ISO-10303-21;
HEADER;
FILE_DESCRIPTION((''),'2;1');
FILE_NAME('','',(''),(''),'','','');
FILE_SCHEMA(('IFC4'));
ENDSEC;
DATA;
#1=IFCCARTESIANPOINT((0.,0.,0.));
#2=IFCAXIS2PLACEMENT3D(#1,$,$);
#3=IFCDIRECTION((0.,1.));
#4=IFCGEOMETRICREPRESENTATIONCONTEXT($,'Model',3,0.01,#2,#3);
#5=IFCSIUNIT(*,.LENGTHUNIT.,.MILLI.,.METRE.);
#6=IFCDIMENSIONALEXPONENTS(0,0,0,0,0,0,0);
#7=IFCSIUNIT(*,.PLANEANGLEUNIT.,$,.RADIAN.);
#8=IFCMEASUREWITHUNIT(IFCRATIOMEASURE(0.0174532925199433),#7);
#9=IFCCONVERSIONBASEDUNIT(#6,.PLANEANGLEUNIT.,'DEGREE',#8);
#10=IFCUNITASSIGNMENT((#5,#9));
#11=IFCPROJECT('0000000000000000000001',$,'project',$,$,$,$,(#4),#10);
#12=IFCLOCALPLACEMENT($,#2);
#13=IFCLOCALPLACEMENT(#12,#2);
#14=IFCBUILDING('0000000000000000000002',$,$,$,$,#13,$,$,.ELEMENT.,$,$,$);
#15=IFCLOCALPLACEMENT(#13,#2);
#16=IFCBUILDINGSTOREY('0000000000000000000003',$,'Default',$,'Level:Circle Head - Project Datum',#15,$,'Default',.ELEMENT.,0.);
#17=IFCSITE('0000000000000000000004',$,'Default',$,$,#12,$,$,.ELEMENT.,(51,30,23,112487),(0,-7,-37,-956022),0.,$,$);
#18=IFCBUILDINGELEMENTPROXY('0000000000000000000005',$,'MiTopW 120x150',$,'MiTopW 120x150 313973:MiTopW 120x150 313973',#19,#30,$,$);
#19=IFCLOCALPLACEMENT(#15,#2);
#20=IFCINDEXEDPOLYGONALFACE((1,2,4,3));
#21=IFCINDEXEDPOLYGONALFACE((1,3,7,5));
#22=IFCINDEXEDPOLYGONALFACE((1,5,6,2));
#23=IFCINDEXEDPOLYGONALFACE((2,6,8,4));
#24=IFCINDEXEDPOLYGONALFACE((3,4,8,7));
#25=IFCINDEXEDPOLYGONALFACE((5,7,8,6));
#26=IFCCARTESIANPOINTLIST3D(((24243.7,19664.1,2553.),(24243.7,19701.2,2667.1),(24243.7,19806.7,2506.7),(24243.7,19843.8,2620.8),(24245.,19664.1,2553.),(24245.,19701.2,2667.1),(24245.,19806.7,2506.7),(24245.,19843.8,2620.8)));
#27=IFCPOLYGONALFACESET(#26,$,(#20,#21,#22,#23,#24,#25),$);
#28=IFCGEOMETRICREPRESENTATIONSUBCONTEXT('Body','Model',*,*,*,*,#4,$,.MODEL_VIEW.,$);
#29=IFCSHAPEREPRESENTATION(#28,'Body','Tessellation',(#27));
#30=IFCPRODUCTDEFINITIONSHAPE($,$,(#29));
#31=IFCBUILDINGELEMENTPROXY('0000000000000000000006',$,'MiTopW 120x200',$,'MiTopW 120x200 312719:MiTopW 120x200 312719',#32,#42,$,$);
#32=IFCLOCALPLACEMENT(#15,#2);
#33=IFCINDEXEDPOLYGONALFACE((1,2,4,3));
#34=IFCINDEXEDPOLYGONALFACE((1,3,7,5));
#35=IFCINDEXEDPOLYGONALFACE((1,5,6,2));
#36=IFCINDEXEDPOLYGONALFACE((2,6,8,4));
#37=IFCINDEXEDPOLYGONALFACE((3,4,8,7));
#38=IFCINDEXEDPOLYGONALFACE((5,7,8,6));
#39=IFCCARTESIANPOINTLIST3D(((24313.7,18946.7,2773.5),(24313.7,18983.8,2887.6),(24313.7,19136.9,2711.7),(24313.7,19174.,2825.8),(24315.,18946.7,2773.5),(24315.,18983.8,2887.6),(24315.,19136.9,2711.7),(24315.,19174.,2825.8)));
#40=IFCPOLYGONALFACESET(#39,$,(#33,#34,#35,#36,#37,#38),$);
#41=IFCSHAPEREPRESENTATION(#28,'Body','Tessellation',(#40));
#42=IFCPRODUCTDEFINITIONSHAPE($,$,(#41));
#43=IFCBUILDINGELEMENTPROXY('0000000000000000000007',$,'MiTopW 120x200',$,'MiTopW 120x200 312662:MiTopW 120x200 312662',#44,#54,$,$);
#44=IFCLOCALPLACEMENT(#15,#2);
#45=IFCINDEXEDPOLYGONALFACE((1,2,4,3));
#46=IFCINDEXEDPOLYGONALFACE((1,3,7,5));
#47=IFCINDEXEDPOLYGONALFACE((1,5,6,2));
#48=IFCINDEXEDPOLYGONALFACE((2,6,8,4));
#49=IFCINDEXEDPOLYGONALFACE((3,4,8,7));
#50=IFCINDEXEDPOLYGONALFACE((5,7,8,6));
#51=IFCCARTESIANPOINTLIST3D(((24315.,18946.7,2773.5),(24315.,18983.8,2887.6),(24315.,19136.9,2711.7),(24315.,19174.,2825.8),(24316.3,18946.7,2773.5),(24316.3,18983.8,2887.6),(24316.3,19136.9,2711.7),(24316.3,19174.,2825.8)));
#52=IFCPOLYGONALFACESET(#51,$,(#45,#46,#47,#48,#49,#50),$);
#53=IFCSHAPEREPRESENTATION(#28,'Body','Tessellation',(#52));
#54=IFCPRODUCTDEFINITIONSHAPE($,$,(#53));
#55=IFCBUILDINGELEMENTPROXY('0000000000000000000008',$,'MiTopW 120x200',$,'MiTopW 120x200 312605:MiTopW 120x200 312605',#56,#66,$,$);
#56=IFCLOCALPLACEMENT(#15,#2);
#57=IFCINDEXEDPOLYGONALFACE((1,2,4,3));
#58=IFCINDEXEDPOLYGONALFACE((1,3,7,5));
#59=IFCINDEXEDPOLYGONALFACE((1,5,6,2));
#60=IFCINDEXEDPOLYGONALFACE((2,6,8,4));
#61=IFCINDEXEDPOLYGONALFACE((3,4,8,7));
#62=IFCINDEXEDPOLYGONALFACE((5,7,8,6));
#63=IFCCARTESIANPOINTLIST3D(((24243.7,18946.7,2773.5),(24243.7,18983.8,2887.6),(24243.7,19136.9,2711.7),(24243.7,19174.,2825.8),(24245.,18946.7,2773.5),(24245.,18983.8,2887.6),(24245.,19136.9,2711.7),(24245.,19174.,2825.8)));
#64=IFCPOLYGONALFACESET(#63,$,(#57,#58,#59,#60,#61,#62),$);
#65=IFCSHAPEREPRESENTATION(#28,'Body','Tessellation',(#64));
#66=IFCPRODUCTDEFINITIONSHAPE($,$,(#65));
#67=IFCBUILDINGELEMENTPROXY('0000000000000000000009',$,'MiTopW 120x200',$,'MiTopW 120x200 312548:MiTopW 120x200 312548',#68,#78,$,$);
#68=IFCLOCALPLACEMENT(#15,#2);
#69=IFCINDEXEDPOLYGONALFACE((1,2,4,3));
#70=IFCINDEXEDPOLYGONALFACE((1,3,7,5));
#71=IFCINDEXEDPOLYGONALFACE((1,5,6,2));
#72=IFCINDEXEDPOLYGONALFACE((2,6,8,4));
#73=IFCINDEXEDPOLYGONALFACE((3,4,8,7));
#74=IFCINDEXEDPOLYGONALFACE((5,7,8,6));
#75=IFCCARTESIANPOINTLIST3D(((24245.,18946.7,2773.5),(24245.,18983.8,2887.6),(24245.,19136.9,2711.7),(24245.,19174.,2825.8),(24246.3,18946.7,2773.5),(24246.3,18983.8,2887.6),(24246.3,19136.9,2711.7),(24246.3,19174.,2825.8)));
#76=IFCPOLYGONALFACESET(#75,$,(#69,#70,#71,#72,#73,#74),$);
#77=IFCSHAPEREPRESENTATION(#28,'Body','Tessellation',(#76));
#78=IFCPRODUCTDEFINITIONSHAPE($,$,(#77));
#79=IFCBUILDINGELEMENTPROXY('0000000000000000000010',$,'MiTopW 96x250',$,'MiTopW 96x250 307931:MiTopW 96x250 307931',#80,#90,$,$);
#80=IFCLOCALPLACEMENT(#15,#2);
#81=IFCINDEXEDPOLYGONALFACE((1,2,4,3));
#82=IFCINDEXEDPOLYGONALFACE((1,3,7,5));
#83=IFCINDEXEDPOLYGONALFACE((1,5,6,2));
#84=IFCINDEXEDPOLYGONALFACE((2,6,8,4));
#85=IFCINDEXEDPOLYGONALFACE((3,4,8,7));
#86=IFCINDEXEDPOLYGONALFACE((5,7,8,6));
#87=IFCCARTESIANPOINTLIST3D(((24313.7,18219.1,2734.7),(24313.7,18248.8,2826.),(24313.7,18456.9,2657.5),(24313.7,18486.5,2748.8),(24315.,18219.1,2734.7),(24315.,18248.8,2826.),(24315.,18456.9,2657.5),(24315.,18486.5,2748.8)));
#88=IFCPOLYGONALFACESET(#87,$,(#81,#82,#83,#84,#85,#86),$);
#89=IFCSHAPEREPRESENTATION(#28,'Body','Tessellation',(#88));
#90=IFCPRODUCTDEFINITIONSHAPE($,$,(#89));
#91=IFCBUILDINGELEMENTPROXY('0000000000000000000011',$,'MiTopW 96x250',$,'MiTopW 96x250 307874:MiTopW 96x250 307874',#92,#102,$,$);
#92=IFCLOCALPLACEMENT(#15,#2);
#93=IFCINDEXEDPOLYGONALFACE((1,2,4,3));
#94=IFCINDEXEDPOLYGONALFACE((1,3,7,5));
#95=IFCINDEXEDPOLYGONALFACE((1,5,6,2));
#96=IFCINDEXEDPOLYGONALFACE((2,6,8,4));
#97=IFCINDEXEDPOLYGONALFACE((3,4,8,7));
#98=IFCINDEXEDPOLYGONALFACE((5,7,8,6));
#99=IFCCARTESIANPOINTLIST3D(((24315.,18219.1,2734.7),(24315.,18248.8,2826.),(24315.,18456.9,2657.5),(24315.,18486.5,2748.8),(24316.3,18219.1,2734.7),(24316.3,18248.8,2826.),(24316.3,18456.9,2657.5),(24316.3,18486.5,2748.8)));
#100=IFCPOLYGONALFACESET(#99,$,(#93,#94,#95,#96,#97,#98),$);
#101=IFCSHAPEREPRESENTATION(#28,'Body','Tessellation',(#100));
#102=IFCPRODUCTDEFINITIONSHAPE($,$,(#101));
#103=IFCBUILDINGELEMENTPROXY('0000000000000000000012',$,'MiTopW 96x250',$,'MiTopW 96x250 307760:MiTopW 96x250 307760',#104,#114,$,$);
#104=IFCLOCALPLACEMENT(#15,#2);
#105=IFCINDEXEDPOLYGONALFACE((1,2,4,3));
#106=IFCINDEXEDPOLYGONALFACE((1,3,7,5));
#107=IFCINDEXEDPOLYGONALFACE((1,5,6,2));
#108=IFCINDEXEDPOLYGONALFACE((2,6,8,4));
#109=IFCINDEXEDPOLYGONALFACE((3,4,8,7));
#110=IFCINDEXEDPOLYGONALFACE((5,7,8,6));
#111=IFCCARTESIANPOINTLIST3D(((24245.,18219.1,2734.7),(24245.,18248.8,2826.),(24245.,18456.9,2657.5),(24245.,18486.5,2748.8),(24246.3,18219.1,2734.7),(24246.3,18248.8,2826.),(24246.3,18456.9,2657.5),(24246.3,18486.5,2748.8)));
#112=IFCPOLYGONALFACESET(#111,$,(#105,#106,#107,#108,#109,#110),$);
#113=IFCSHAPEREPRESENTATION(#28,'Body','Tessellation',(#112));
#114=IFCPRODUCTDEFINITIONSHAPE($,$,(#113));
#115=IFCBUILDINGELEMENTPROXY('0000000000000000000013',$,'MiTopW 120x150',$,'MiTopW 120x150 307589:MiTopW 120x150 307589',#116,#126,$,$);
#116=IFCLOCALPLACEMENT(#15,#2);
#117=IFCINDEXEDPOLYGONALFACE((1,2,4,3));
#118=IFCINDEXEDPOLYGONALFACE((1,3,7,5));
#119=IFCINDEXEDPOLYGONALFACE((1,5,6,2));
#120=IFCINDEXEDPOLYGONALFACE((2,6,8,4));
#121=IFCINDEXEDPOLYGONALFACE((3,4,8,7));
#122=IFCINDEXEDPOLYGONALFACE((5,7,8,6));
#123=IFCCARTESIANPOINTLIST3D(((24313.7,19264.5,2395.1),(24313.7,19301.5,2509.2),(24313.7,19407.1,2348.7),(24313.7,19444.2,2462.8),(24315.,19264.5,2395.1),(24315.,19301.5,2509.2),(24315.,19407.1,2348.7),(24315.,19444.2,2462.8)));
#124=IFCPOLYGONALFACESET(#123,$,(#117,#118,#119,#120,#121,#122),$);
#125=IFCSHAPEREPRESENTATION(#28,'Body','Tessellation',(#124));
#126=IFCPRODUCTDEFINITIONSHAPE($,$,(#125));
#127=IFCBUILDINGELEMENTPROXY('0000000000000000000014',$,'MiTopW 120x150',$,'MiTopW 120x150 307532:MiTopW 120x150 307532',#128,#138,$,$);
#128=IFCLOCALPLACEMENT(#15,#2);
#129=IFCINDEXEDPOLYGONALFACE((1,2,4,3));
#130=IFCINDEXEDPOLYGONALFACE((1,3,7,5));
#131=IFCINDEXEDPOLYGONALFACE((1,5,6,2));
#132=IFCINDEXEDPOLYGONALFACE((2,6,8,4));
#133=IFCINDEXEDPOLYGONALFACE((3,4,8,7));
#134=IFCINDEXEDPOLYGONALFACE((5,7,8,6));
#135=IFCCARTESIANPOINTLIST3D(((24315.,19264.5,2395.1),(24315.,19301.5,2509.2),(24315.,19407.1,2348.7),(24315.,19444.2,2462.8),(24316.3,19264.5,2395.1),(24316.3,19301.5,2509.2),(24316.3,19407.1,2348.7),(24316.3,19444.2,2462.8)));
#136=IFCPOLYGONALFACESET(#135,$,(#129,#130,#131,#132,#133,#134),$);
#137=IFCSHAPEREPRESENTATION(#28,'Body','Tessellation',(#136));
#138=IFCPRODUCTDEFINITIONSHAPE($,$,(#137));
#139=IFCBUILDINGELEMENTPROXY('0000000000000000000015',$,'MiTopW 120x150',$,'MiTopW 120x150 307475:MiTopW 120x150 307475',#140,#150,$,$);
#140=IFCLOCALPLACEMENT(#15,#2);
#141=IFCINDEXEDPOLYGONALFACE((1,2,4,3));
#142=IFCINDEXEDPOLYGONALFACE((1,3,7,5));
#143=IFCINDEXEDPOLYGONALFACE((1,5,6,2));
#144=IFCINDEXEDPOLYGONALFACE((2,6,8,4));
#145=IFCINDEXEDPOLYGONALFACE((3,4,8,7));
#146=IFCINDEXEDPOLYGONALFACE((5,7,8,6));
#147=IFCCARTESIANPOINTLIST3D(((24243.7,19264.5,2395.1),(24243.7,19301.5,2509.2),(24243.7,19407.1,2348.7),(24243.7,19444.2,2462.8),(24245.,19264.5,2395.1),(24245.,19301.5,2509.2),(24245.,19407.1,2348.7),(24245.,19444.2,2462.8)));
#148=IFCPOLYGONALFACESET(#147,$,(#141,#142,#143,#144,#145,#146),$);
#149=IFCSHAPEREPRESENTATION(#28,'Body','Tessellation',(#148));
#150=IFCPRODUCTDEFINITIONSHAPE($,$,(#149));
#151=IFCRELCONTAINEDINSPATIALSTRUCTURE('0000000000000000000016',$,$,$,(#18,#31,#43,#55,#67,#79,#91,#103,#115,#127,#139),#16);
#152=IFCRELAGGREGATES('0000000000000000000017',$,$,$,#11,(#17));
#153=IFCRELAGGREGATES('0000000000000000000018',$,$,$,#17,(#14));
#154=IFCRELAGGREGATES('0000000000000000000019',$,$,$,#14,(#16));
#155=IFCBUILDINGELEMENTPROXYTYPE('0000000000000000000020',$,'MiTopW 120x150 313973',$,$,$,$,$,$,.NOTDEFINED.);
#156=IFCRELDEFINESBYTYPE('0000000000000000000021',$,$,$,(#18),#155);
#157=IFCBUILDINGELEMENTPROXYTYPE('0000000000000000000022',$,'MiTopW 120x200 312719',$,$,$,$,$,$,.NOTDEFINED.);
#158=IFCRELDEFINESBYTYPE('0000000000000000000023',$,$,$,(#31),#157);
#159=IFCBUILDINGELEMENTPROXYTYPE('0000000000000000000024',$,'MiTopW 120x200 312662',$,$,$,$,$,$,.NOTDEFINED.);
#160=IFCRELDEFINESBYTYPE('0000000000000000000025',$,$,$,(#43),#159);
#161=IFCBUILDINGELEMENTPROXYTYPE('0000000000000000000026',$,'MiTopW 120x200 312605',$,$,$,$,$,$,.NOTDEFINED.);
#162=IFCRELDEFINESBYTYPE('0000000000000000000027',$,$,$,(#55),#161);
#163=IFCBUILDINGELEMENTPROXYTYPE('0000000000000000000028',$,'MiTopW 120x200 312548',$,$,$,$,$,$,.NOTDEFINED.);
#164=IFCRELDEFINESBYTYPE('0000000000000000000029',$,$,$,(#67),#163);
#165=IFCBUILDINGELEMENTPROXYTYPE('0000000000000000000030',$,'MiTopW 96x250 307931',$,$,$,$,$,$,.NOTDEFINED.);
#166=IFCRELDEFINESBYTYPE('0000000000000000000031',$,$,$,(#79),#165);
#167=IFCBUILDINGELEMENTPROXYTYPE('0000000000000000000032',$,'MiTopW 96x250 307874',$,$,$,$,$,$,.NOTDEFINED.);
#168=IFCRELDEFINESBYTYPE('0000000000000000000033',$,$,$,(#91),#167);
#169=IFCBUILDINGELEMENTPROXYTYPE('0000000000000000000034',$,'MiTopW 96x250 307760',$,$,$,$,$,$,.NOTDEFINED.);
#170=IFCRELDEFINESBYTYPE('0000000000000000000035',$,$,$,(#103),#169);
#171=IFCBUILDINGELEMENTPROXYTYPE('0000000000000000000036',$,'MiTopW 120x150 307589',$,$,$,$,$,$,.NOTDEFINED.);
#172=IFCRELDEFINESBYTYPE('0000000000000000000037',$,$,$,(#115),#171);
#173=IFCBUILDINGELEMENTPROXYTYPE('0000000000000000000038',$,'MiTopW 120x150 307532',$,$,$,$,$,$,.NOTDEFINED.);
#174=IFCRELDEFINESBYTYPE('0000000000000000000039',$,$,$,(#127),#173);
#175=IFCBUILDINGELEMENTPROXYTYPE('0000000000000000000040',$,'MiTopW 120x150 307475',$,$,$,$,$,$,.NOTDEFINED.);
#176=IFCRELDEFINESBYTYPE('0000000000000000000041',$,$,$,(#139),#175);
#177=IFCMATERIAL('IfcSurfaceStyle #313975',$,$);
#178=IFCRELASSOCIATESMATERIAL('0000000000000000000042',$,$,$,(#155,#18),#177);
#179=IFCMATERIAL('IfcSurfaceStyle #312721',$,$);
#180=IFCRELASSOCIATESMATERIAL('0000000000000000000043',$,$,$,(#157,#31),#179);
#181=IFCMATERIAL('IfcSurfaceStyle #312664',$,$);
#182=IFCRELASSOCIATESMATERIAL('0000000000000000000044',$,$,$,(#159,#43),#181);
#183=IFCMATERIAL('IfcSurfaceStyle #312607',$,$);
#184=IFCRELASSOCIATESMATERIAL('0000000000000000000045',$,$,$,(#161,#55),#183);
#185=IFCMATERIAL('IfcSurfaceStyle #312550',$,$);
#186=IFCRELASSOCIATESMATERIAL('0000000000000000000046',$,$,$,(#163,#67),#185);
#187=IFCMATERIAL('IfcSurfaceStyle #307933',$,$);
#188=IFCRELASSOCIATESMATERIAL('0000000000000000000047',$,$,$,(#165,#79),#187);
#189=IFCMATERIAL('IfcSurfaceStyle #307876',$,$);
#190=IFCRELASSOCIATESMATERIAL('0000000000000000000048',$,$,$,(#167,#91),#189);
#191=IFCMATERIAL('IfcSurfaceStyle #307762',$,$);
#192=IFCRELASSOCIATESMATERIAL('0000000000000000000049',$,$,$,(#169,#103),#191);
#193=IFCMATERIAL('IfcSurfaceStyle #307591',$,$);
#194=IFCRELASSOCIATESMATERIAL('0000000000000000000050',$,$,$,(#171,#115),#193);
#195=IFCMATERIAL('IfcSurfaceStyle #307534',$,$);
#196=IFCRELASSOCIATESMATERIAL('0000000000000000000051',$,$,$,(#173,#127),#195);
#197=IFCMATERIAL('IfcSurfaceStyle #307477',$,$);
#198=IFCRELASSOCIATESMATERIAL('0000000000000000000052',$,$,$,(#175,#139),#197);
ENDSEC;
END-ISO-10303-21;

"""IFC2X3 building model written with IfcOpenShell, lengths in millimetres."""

from ifc_helpers import new_model, entity, si_unit, converted_unit, direction, frame, origin, place, context, subcontext, project, spatial, polyline, outline, extrude, source, transform, mapped, material, type_object, type_shapes, element, save


model = new_model("IFC2X3")

# Units and contexts
model_context = context("Model", 3, precision=0.01, world=origin(), true_north=direction((0.0, 1.0)))
body_context = subcontext(model_context, "Body", "Model", "MODEL_VIEW")
ifc_project = project(units=[si_unit("LENGTHUNIT", "METRE", prefix="MILLI"), converted_unit("PLANEANGLEUNIT", "DEGREE", entity("IfcRatioMeasure", 0.0174532925199433), si_unit("PLANEANGLEUNIT", "RADIAN"), dimensions=[0, 0, 0, 0, 0, 0, 0])], contexts=[model_context])

# Site, building, storey
site_placement = place(None, origin())
site = spatial("IfcSite", under=ifc_project, at=site_placement, Name="Default", CompositionType="ELEMENT", RefLatitude=(51, 30, 23, 112487), RefLongitude=(0, -7, -37, -956022), RefElevation=0.0)
building_placement = place(site_placement, origin())
building = spatial("IfcBuilding", under=site, at=building_placement, CompositionType="ELEMENT")
storey_placement = place(building_placement, origin())
storey = spatial("IfcBuildingStorey", under=building, at=storey_placement, Name="Default", ObjectType="Level:Circle Head - Project Datum", LongName="Default", CompositionType="ELEMENT", Elevation=0.0)

# Building element proxies
ifc_material_1 = material(Name="IfcSurfaceStyle #313975")
building_element_proxy_type_1 = type_object("IfcBuildingElementProxyType", Name="MiTopW 120x150 313973", PredefinedType="NOTDEFINED", material=ifc_material_1)
shared_shape_1 = source(origin(), body_context, "Body", "SweptSolid", [
    extrude(outline(polyline([(-75.0, -60.0), (75.0, -60.0), (75.0, 60.0), (-75.0, 60.0), (-75.0, -60.0)])), frame((75.0, 60.0, 0.0), z_axis=(0.0, 0.0, 1.0), x_axis=(-1.0, 0.0, 0.0)), (0.0, 0.0, 1.0), 1.3),
])
type_shapes(building_element_proxy_type_1, [shared_shape_1])
proxy_1_placement = place(building_placement, frame((24245.0, 19806.7, 2506.7), z_axis=(-1.0, 0.0, 0.0), x_axis=(0.0, -0.951057, 0.309017)))
element("IfcBuildingElementProxy", 1, at=proxy_1_placement, inside=storey, type_object=building_element_proxy_type_1, material=ifc_material_1, Name="MiTopW 120x150", ObjectType="MiTopW 120x150 313973:MiTopW 120x150 313973", context=body_context, shape_type="MappedRepresentation", body=[
    mapped(shared_shape_1, transform((0.0, 0.0, 0.0), scale=1.0)),
])
ifc_material_2 = material(Name="IfcSurfaceStyle #312721")
building_element_proxy_type_2 = type_object("IfcBuildingElementProxyType", Name="MiTopW 120x200 312719", PredefinedType="NOTDEFINED", material=ifc_material_2)
shared_shape_2 = source(origin(), body_context, "Body", "SweptSolid", [
    extrude(outline(polyline([(-100.0, -60.0), (100.0, -60.0), (100.0, 60.0), (-100.0, 60.0), (-100.0, -60.0)])), frame((100.0, 60.0, 0.0), z_axis=(0.0, 0.0, 1.0), x_axis=(-1.0, 0.0, 0.0)), (0.0, 0.0, 1.0), 1.3),
])
type_shapes(building_element_proxy_type_2, [shared_shape_2])
proxy_2_placement = place(building_placement, frame((24315.0, 19136.9, 2711.7), z_axis=(-1.0, 0.0, 0.0), x_axis=(0.0, -0.951057, 0.309017)))
element("IfcBuildingElementProxy", 2, at=proxy_2_placement, inside=storey, type_object=building_element_proxy_type_2, material=ifc_material_2, Name="MiTopW 120x200", ObjectType="MiTopW 120x200 312719:MiTopW 120x200 312719", context=body_context, shape_type="MappedRepresentation", body=[
    mapped(shared_shape_2, transform((0.0, 0.0, 0.0), scale=1.0)),
])
ifc_material_3 = material(Name="IfcSurfaceStyle #312664")
building_element_proxy_type_3 = type_object("IfcBuildingElementProxyType", Name="MiTopW 120x200 312662", PredefinedType="NOTDEFINED", material=ifc_material_3)
shared_shape_3 = source(origin(), body_context, "Body", "SweptSolid", [
    extrude(outline(polyline([(-100.0, -60.0), (100.0, -60.0), (100.0, 60.0), (-100.0, 60.0), (-100.0, -60.0)])), frame((100.0, 60.0, 0.0), z_axis=(0.0, 0.0, 1.0), x_axis=(-1.0, 0.0, 0.0)), (0.0, 0.0, 1.0), 1.3),
])
type_shapes(building_element_proxy_type_3, [shared_shape_3])
proxy_3_placement = place(building_placement, frame((24316.3, 19136.9, 2711.7), z_axis=(-1.0, 0.0, 0.0), x_axis=(0.0, -0.951057, 0.309017)))
element("IfcBuildingElementProxy", 3, at=proxy_3_placement, inside=storey, type_object=building_element_proxy_type_3, material=ifc_material_3, Name="MiTopW 120x200", ObjectType="MiTopW 120x200 312662:MiTopW 120x200 312662", context=body_context, shape_type="MappedRepresentation", body=[
    mapped(shared_shape_3, transform((0.0, 0.0, 0.0), scale=1.0)),
])
ifc_material_4 = material(Name="IfcSurfaceStyle #312607")
building_element_proxy_type_4 = type_object("IfcBuildingElementProxyType", Name="MiTopW 120x200 312605", PredefinedType="NOTDEFINED", material=ifc_material_4)
shared_shape_4 = source(origin(), body_context, "Body", "SweptSolid", [
    extrude(outline(polyline([(-100.0, -60.0), (100.0, -60.0), (100.0, 60.0), (-100.0, 60.0), (-100.0, -60.0)])), frame((100.0, 60.0, 0.0), z_axis=(0.0, 0.0, 1.0), x_axis=(-1.0, 0.0, 0.0)), (0.0, 0.0, 1.0), 1.3),
])
type_shapes(building_element_proxy_type_4, [shared_shape_4])
proxy_4_placement = place(building_placement, frame((24245.0, 19136.9, 2711.7), z_axis=(-1.0, 0.0, 0.0), x_axis=(0.0, -0.951057, 0.309017)))
element("IfcBuildingElementProxy", 4, at=proxy_4_placement, inside=storey, type_object=building_element_proxy_type_4, material=ifc_material_4, Name="MiTopW 120x200", ObjectType="MiTopW 120x200 312605:MiTopW 120x200 312605", context=body_context, shape_type="MappedRepresentation", body=[
    mapped(shared_shape_4, transform((0.0, 0.0, 0.0), scale=1.0)),
])
ifc_material_5 = material(Name="IfcSurfaceStyle #312550")
building_element_proxy_type_5 = type_object("IfcBuildingElementProxyType", Name="MiTopW 120x200 312548", PredefinedType="NOTDEFINED", material=ifc_material_5)
shared_shape_5 = source(origin(), body_context, "Body", "SweptSolid", [
    extrude(outline(polyline([(-100.0, -60.0), (100.0, -60.0), (100.0, 60.0), (-100.0, 60.0), (-100.0, -60.0)])), frame((100.0, 60.0, 0.0), z_axis=(0.0, 0.0, 1.0), x_axis=(-1.0, 0.0, 0.0)), (0.0, 0.0, 1.0), 1.3),
])
type_shapes(building_element_proxy_type_5, [shared_shape_5])
proxy_5_placement = place(building_placement, frame((24246.3, 19136.9, 2711.7), z_axis=(-1.0, 0.0, 0.0), x_axis=(0.0, -0.951057, 0.309017)))
element("IfcBuildingElementProxy", 5, at=proxy_5_placement, inside=storey, type_object=building_element_proxy_type_5, material=ifc_material_5, Name="MiTopW 120x200", ObjectType="MiTopW 120x200 312548:MiTopW 120x200 312548", context=body_context, shape_type="MappedRepresentation", body=[
    mapped(shared_shape_5, transform((0.0, 0.0, 0.0), scale=1.0)),
])
ifc_material_6 = material(Name="IfcSurfaceStyle #307933")
building_element_proxy_type_6 = type_object("IfcBuildingElementProxyType", Name="MiTopW 96x250 307931", PredefinedType="NOTDEFINED", material=ifc_material_6)
shared_shape_6 = source(origin(), body_context, "Body", "SweptSolid", [
    extrude(outline(polyline([(-125.0, -48.0), (125.0, -48.0), (125.0, 48.0), (-125.0, 48.0), (-125.0, -48.0)])), frame((125.0, 48.0, 0.0), z_axis=(0.0, 0.0, 1.0), x_axis=(-1.0, 0.0, 0.0)), (0.0, 0.0, 1.0), 1.3),
])
type_shapes(building_element_proxy_type_6, [shared_shape_6])
proxy_6_placement = place(building_placement, frame((24315.0, 18456.9, 2657.5), z_axis=(-1.0, 0.0, 0.0), x_axis=(0.0, -0.951057, 0.309017)))
element("IfcBuildingElementProxy", 6, at=proxy_6_placement, inside=storey, type_object=building_element_proxy_type_6, material=ifc_material_6, Name="MiTopW 96x250", ObjectType="MiTopW 96x250 307931:MiTopW 96x250 307931", context=body_context, shape_type="MappedRepresentation", body=[
    mapped(shared_shape_6, transform((0.0, 0.0, 0.0), scale=1.0)),
])
ifc_material_7 = material(Name="IfcSurfaceStyle #307876")
building_element_proxy_type_7 = type_object("IfcBuildingElementProxyType", Name="MiTopW 96x250 307874", PredefinedType="NOTDEFINED", material=ifc_material_7)
shared_shape_7 = source(origin(), body_context, "Body", "SweptSolid", [
    extrude(outline(polyline([(-125.0, -48.0), (125.0, -48.0), (125.0, 48.0), (-125.0, 48.0), (-125.0, -48.0)])), frame((125.0, 48.0, 0.0), z_axis=(0.0, 0.0, 1.0), x_axis=(-1.0, 0.0, 0.0)), (0.0, 0.0, 1.0), 1.3),
])
type_shapes(building_element_proxy_type_7, [shared_shape_7])
proxy_7_placement = place(building_placement, frame((24316.3, 18456.9, 2657.5), z_axis=(-1.0, 0.0, 0.0), x_axis=(0.0, -0.951057, 0.309017)))
element("IfcBuildingElementProxy", 7, at=proxy_7_placement, inside=storey, type_object=building_element_proxy_type_7, material=ifc_material_7, Name="MiTopW 96x250", ObjectType="MiTopW 96x250 307874:MiTopW 96x250 307874", context=body_context, shape_type="MappedRepresentation", body=[
    mapped(shared_shape_7, transform((0.0, 0.0, 0.0), scale=1.0)),
])
ifc_material_8 = material(Name="IfcSurfaceStyle #307762")
building_element_proxy_type_8 = type_object("IfcBuildingElementProxyType", Name="MiTopW 96x250 307760", PredefinedType="NOTDEFINED", material=ifc_material_8)
shared_shape_8 = source(origin(), body_context, "Body", "SweptSolid", [
    extrude(outline(polyline([(-125.0, -48.0), (125.0, -48.0), (125.0, 48.0), (-125.0, 48.0), (-125.0, -48.0)])), frame((125.0, 48.0, 0.0), z_axis=(0.0, 0.0, 1.0), x_axis=(-1.0, 0.0, 0.0)), (0.0, 0.0, 1.0), 1.3),
])
type_shapes(building_element_proxy_type_8, [shared_shape_8])
proxy_8_placement = place(building_placement, frame((24246.3, 18456.9, 2657.5), z_axis=(-1.0, 0.0, 0.0), x_axis=(0.0, -0.951057, 0.309017)))
element("IfcBuildingElementProxy", 8, at=proxy_8_placement, inside=storey, type_object=building_element_proxy_type_8, material=ifc_material_8, Name="MiTopW 96x250", ObjectType="MiTopW 96x250 307760:MiTopW 96x250 307760", context=body_context, shape_type="MappedRepresentation", body=[
    mapped(shared_shape_8, transform((0.0, 0.0, 0.0), scale=1.0)),
])
ifc_material_9 = material(Name="IfcSurfaceStyle #307591")
building_element_proxy_type_9 = type_object("IfcBuildingElementProxyType", Name="MiTopW 120x150 307589", PredefinedType="NOTDEFINED", material=ifc_material_9)
shared_shape_9 = source(origin(), body_context, "Body", "SweptSolid", [
    extrude(outline(polyline([(-75.0, -60.0), (75.0, -60.0), (75.0, 60.0), (-75.0, 60.0), (-75.0, -60.0)])), frame((75.0, 60.0, 0.0), z_axis=(0.0, 0.0, 1.0), x_axis=(-1.0, 0.0, 0.0)), (0.0, 0.0, 1.0), 1.3),
])
type_shapes(building_element_proxy_type_9, [shared_shape_9])
proxy_9_placement = place(building_placement, frame((24315.0, 19407.1, 2348.7), z_axis=(-1.0, 0.0, 0.0), x_axis=(0.0, -0.951057, 0.309017)))
element("IfcBuildingElementProxy", 9, at=proxy_9_placement, inside=storey, type_object=building_element_proxy_type_9, material=ifc_material_9, Name="MiTopW 120x150", ObjectType="MiTopW 120x150 307589:MiTopW 120x150 307589", context=body_context, shape_type="MappedRepresentation", body=[
    mapped(shared_shape_9, transform((0.0, 0.0, 0.0), scale=1.0)),
])
ifc_material_10 = material(Name="IfcSurfaceStyle #307534")
building_element_proxy_type_10 = type_object("IfcBuildingElementProxyType", Name="MiTopW 120x150 307532", PredefinedType="NOTDEFINED", material=ifc_material_10)
shared_shape_10 = source(origin(), body_context, "Body", "SweptSolid", [
    extrude(outline(polyline([(-75.0, -60.0), (75.0, -60.0), (75.0, 60.0), (-75.0, 60.0), (-75.0, -60.0)])), frame((75.0, 60.0, 0.0), z_axis=(0.0, 0.0, 1.0), x_axis=(-1.0, 0.0, 0.0)), (0.0, 0.0, 1.0), 1.3),
])
type_shapes(building_element_proxy_type_10, [shared_shape_10])
proxy_10_placement = place(building_placement, frame((24316.3, 19407.1, 2348.7), z_axis=(-1.0, 0.0, 0.0), x_axis=(0.0, -0.951057, 0.309017)))
element("IfcBuildingElementProxy", 10, at=proxy_10_placement, inside=storey, type_object=building_element_proxy_type_10, material=ifc_material_10, Name="MiTopW 120x150", ObjectType="MiTopW 120x150 307532:MiTopW 120x150 307532", context=body_context, shape_type="MappedRepresentation", body=[
    mapped(shared_shape_10, transform((0.0, 0.0, 0.0), scale=1.0)),
])
ifc_material_11 = material(Name="IfcSurfaceStyle #307477")
building_element_proxy_type_11 = type_object("IfcBuildingElementProxyType", Name="MiTopW 120x150 307475", PredefinedType="NOTDEFINED", material=ifc_material_11)
shared_shape_11 = source(origin(), body_context, "Body", "SweptSolid", [
    extrude(outline(polyline([(-75.0, -60.0), (75.0, -60.0), (75.0, 60.0), (-75.0, 60.0), (-75.0, -60.0)])), frame((75.0, 60.0, 0.0), z_axis=(0.0, 0.0, 1.0), x_axis=(-1.0, 0.0, 0.0)), (0.0, 0.0, 1.0), 1.3),
])
type_shapes(building_element_proxy_type_11, [shared_shape_11])
proxy_11_placement = place(building_placement, frame((24245.0, 19407.1, 2348.7), z_axis=(-1.0, 0.0, 0.0), x_axis=(0.0, -0.951057, 0.309017)))
element("IfcBuildingElementProxy", 11, at=proxy_11_placement, inside=storey, type_object=building_element_proxy_type_11, material=ifc_material_11, Name="MiTopW 120x150", ObjectType="MiTopW 120x150 307475:MiTopW 120x150 307475", context=body_context, shape_type="MappedRepresentation", body=[
    mapped(shared_shape_11, transform((0.0, 0.0, 0.0), scale=1.0)),
])

save(model, "model.ifc")
